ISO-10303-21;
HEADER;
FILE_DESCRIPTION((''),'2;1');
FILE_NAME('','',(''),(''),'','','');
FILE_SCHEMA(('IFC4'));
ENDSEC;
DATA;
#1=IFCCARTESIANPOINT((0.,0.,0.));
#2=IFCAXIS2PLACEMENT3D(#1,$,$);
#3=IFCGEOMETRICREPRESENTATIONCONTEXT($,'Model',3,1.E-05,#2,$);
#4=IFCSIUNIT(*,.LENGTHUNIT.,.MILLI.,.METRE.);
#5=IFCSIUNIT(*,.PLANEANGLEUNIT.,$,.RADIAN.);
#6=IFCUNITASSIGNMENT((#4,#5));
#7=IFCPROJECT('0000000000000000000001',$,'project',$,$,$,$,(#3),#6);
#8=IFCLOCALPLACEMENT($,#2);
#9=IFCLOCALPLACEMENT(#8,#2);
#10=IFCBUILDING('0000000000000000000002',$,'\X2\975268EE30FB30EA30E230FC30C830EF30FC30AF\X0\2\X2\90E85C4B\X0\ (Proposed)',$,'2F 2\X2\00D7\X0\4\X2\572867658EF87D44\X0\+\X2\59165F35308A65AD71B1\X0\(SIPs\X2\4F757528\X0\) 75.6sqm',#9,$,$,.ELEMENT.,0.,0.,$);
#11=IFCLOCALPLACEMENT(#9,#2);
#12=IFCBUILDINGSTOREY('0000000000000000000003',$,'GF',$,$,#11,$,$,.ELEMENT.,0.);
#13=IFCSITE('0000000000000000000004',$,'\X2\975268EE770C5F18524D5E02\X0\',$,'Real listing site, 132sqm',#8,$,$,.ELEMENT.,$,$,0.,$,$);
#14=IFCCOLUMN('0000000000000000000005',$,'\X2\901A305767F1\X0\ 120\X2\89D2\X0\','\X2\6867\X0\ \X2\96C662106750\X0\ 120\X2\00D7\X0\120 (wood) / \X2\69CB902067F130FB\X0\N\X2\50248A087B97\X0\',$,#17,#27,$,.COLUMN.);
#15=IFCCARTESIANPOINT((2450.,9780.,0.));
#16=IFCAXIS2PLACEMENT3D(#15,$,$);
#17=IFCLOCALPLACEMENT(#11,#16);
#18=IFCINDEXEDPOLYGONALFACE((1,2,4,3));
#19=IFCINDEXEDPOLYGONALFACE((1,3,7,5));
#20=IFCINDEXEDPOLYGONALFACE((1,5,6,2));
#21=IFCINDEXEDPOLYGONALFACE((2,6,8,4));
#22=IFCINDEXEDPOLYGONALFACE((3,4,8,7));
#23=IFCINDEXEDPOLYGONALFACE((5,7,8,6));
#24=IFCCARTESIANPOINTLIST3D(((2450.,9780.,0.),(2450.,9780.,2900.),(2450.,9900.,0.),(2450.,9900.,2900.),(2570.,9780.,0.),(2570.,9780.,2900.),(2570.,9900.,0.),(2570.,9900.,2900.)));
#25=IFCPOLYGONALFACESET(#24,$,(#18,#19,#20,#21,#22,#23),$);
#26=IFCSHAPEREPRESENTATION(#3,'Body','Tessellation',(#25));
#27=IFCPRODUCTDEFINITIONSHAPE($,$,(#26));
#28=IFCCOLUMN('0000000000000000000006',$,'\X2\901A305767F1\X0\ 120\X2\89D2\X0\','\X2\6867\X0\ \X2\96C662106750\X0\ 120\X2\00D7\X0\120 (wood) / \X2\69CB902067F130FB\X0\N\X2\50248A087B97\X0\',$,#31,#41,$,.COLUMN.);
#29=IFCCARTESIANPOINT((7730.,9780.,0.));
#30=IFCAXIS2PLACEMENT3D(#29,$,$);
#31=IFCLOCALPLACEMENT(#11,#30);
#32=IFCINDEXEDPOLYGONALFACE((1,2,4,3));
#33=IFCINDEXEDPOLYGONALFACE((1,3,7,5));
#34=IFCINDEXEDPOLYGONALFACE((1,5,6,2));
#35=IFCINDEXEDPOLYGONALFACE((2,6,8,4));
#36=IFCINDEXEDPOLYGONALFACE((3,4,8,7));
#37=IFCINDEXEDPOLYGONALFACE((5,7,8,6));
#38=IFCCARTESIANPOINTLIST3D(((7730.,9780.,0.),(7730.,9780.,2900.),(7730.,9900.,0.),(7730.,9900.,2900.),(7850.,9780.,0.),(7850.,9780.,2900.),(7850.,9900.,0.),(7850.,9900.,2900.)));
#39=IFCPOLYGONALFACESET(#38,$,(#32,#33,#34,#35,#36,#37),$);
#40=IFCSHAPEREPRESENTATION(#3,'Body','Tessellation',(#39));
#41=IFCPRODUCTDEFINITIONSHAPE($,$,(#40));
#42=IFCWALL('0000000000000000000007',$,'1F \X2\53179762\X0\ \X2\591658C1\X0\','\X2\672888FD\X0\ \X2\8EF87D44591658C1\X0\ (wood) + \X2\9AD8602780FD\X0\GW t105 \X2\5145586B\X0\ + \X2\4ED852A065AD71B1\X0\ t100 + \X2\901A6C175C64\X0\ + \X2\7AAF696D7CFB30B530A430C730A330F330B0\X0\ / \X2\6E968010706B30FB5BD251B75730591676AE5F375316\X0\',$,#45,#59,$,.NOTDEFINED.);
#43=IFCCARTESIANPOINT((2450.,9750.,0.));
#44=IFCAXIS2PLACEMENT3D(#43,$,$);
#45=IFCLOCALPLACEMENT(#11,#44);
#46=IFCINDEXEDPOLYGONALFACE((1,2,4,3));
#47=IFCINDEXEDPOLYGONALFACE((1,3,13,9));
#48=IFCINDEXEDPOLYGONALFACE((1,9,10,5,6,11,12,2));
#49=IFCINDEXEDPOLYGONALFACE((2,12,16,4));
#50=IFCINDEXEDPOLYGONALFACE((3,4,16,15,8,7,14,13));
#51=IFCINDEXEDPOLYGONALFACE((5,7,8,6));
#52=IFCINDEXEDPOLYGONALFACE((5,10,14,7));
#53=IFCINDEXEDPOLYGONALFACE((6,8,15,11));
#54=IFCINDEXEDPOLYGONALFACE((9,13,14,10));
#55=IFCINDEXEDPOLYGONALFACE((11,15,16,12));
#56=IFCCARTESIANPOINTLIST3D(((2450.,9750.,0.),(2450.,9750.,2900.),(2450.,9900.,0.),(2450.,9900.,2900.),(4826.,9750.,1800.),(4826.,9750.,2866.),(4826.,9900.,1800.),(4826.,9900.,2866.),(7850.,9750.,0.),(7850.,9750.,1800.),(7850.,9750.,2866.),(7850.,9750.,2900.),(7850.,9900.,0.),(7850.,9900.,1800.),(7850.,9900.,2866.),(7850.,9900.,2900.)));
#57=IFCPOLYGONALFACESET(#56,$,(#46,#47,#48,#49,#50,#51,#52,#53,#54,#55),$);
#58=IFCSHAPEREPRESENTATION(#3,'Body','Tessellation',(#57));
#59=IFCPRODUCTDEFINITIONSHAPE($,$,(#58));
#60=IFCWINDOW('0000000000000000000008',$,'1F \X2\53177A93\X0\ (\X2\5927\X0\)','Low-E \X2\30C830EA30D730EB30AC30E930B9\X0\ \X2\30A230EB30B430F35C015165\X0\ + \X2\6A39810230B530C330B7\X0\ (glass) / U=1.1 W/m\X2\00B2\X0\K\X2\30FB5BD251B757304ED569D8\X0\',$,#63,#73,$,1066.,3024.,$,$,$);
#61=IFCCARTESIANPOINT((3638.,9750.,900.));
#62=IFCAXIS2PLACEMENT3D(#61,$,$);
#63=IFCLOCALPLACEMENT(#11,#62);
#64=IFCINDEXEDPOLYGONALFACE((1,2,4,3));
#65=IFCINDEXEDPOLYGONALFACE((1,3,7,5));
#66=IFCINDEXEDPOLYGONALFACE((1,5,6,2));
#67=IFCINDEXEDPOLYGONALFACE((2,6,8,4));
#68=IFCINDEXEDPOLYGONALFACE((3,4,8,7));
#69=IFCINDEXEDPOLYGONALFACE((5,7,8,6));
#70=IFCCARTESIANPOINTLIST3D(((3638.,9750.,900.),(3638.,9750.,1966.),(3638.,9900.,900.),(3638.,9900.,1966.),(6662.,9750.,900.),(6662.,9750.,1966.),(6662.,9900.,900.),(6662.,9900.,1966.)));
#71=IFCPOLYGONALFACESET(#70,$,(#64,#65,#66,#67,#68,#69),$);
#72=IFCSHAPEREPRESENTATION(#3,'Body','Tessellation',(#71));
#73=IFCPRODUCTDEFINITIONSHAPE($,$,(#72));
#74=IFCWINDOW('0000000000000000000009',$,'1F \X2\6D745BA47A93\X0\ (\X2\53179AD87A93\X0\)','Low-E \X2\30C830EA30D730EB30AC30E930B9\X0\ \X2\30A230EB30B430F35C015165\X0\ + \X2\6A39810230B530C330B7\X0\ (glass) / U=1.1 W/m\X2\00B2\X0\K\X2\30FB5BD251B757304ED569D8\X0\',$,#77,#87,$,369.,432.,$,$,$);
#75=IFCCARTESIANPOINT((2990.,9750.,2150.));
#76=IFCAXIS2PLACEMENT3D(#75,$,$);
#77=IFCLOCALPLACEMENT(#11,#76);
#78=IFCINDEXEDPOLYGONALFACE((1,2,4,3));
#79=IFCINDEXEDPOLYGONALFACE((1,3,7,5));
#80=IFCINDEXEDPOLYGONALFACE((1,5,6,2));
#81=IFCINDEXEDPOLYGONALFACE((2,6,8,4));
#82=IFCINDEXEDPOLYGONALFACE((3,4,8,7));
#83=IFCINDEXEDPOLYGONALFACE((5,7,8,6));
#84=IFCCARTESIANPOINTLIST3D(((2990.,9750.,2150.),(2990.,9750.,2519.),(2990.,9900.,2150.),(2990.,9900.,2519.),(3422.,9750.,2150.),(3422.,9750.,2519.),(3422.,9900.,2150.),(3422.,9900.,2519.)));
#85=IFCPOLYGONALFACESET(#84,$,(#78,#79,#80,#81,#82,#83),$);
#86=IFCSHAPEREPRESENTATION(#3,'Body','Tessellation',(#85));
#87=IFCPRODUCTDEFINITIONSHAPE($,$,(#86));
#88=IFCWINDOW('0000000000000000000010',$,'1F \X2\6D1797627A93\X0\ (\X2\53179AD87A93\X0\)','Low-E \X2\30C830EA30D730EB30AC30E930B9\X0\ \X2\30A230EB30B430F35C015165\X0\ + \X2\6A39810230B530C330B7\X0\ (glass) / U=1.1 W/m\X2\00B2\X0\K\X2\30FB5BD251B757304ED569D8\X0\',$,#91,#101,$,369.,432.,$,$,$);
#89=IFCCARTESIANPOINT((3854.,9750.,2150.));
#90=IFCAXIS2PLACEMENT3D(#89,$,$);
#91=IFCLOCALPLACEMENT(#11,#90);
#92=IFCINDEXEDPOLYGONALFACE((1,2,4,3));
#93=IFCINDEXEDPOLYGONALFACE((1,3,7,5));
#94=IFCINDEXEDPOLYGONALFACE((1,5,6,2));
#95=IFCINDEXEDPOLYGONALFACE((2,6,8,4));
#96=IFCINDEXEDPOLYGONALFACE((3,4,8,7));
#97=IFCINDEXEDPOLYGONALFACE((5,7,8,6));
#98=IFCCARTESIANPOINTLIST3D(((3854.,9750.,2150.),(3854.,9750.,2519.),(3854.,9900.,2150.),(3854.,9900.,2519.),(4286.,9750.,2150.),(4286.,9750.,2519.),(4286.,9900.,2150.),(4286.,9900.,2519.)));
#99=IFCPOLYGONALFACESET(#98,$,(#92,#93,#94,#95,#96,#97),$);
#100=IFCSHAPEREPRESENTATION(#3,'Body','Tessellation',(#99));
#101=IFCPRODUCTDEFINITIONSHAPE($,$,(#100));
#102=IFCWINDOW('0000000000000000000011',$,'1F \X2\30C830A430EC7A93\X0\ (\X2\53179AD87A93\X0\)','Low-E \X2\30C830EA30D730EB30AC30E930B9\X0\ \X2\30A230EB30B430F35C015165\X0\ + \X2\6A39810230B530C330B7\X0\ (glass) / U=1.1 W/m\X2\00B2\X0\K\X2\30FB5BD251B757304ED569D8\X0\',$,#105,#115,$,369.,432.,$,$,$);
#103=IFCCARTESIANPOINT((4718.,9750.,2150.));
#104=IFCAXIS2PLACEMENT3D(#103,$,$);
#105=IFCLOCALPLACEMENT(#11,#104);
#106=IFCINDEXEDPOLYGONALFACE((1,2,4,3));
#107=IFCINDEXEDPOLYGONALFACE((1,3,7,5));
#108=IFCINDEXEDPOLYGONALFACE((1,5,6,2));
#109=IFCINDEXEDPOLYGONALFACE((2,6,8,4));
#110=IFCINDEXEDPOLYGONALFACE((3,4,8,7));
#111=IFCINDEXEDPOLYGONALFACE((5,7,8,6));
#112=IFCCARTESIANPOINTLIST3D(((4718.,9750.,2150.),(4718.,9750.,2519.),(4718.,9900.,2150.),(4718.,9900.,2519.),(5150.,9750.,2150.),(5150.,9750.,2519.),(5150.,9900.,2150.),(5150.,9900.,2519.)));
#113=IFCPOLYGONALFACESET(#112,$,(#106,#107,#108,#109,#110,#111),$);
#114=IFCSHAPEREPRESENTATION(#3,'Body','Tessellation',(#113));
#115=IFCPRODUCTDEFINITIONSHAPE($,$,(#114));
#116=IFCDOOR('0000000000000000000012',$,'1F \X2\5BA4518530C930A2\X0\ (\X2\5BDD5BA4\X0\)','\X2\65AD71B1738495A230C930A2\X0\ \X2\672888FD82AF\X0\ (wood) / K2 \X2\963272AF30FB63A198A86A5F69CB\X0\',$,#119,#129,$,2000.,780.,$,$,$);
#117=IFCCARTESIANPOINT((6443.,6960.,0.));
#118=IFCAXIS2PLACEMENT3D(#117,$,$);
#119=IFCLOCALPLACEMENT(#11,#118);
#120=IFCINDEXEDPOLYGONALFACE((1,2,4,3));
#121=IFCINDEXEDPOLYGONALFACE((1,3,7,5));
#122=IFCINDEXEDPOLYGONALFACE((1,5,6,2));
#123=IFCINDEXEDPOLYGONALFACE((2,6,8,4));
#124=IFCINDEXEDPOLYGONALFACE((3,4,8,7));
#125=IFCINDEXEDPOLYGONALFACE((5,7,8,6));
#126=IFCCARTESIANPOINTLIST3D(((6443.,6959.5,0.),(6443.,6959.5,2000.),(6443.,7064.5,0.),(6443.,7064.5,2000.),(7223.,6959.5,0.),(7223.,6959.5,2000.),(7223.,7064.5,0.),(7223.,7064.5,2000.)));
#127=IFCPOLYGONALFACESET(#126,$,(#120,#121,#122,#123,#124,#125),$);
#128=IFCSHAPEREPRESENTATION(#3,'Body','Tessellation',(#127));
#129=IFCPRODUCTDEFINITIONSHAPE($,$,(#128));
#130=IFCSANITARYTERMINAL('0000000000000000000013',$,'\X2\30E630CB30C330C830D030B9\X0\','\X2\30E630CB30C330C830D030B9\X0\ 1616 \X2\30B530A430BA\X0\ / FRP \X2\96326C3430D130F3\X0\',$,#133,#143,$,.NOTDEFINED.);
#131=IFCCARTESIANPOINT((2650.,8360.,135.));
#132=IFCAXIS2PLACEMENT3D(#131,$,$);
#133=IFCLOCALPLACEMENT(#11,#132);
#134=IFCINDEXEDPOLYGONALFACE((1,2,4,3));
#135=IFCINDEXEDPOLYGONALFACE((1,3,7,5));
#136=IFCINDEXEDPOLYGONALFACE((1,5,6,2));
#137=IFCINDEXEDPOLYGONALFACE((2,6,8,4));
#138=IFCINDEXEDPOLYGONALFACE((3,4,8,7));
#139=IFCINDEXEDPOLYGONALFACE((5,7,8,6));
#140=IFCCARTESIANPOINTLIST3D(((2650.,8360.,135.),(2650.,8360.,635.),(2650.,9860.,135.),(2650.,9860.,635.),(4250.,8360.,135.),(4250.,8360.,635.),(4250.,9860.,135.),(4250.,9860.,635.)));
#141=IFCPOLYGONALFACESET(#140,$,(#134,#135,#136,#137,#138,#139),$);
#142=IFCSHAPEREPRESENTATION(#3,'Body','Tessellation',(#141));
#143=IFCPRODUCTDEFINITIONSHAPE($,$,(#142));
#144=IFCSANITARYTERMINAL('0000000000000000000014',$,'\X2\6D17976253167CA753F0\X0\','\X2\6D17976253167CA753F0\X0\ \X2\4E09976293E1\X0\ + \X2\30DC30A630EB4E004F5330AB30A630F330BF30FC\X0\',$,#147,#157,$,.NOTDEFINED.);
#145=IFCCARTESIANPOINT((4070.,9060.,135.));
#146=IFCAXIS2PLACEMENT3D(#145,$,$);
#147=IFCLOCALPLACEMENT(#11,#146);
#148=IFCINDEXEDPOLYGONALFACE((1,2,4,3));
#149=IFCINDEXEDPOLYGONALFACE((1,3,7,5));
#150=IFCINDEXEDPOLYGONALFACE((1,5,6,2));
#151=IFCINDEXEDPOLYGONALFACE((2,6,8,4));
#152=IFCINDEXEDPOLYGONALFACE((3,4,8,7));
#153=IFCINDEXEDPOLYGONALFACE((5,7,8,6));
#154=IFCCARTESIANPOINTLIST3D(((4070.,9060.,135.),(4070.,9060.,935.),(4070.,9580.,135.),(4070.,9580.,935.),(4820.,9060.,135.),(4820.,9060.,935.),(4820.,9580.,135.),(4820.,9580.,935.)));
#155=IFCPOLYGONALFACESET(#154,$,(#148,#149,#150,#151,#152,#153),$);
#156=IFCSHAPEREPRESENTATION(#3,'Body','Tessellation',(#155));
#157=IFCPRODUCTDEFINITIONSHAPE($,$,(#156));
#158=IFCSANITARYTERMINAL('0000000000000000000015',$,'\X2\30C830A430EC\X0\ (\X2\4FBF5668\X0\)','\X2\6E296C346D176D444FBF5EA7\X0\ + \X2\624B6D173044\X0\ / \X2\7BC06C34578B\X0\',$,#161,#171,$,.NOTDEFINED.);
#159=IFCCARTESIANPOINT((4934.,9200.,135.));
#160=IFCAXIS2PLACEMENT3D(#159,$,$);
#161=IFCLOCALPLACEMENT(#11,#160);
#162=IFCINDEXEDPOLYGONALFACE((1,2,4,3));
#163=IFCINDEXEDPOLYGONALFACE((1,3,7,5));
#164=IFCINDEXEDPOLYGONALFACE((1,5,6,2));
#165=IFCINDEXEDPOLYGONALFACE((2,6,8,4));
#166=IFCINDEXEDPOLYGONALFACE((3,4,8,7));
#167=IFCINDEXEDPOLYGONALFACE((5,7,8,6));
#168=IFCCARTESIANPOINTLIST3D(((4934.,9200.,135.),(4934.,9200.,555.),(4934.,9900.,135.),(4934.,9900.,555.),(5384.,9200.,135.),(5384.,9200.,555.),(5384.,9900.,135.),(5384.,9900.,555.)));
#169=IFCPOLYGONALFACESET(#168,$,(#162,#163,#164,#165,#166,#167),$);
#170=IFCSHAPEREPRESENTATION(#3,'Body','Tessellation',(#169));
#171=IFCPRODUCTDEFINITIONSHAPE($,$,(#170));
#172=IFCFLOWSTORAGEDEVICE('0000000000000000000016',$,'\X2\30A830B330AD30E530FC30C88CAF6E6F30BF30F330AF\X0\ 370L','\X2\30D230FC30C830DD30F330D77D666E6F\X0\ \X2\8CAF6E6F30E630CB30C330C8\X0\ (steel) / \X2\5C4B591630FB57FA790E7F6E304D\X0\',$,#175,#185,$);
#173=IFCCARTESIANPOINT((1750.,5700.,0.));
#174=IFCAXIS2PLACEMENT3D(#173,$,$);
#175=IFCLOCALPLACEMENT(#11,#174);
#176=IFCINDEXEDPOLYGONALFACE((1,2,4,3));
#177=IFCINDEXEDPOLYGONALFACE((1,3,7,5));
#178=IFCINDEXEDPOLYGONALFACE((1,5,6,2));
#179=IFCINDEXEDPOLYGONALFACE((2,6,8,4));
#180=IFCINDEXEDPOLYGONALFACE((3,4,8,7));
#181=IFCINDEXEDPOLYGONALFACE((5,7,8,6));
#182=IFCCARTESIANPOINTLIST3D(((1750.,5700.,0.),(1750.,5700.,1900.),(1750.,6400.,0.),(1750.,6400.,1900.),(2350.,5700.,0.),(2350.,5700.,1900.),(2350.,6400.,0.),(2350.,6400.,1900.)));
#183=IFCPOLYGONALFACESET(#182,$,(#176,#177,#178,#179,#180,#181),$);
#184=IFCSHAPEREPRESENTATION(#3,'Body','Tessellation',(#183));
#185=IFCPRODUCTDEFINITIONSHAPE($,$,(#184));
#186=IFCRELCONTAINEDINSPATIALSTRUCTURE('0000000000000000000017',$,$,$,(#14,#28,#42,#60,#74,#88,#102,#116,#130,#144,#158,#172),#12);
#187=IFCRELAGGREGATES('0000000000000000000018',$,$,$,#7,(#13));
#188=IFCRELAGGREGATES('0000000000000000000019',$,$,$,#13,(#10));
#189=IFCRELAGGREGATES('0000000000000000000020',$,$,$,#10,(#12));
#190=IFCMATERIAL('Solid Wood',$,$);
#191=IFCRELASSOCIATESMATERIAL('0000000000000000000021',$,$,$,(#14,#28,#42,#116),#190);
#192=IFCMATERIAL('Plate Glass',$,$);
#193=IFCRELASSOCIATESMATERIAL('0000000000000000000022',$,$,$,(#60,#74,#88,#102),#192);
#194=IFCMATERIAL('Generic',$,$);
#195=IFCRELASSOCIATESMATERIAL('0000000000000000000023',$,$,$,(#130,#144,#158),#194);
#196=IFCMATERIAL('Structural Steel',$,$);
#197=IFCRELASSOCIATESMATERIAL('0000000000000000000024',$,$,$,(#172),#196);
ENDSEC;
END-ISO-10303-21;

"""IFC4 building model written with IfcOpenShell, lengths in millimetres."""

from ifc_helpers import new_model, si_unit, frame, frame_2d, origin, place, context, project, spatial, rectangle, extrude, material, element, fill, save


model = new_model("IFC4")

# Units and contexts
model_context = context("Model", 3, precision=1e-05, world=origin())
ifc_project = project(units=[si_unit("LENGTHUNIT", "METRE", prefix="MILLI"), si_unit("PLANEANGLEUNIT", "RADIAN")], contexts=[model_context])

# Site, building, storey
site_placement = place(None, origin())
site = spatial("IfcSite", under=ifc_project, at=site_placement, Name="青森県弘前市", ObjectType="Real listing site, 132sqm", CompositionType="ELEMENT", RefElevation=0.0)
building_placement = place(site_placement, origin())
building = spatial("IfcBuilding", under=site, at=building_placement, Name="青森・リモートワーク2部屋 (Proposed)", ObjectType="2F 2×4在来軸組+外張り断熱(SIPs併用) 75.6sqm", CompositionType="ELEMENT", ElevationOfRefHeight=0.0, ElevationOfTerrain=0.0)
storey_placement = place(building_placement, origin())
storey = spatial("IfcBuildingStorey", under=building, at=storey_placement, Name="GF", CompositionType="ELEMENT", Elevation=0.0)

# Columns
ifc_material_1 = material(Name="Solid Wood")
column_1_placement = place(storey_placement, frame((2450.0, 9780.0, 0.0)))
element("IfcColumn", 1, at=column_1_placement, inside=storey, material=ifc_material_1, Name="通し柱 120角", Description="桧 集成材 120×120 (wood) / 構造柱・N値計算", PredefinedType="COLUMN", context=model_context, shape_type="SweptSolid", body=[
    extrude(rectangle(XDim=120.0, YDim=120.0, at=frame_2d((60.0, 60.0))), frame((2450.0, 9780.0, 0.0)), (0.0, 0.0, 1.0), 2900.0),
])
column_2_placement = place(storey_placement, frame((7730.0, 9780.0, 0.0)))
element("IfcColumn", 2, at=column_2_placement, inside=storey, material=ifc_material_1, Name="通し柱 120角", Description="桧 集成材 120×120 (wood) / 構造柱・N値計算", PredefinedType="COLUMN", context=model_context, shape_type="SweptSolid", body=[
    extrude(rectangle(XDim=120.0, YDim=120.0, at=frame_2d((60.0, 60.0))), frame((7730.0, 9780.0, 0.0)), (0.0, 0.0, 1.0), 2900.0),
])

# Wall, openings, windows
wall_1_placement = place(storey_placement, frame((2450.0, 9750.0, 0.0)))
wall_1 = element("IfcWall", 3, at=wall_1_placement, inside=storey, material=ifc_material_1, Name="1F 北面 外壁", Description="木製 軸組外壁 (wood) + 高性能GW t105 充填 + 付加断熱 t100 + 通気層 + 窯業系サイディング / 準耐火・寒冷地外皮強化", PredefinedType="NOTDEFINED", context=model_context, shape_type="SweptSolid", body=[
    extrude(rectangle(XDim=5400.0, YDim=150.0, at=frame_2d((2700.0, 75.0))), frame((2450.0, 9750.0, 0.0)), (0.0, 0.0, 1.0), 2900.0),
])
opening_1_placement = place(storey_placement, frame((3638.0, 9750.0, 900.0)))
opening_1 = element("IfcOpeningElement", 4, at=opening_1_placement, cuts=wall_1, PredefinedType="NOTDEFINED", context=model_context, shape_type="SweptSolid", body=[
    extrude(rectangle(XDim=3024.0, YDim=150.0, at=frame_2d((1512.0, 75.0))), frame((3638.0, 9750.0, 900.0)), (0.0, 0.0, 1.0), 1066.0),
])
opening_2_placement = place(storey_placement, frame((2990.0, 9750.0, 2150.0)))
opening_2 = element("IfcOpeningElement", 5, at=opening_2_placement, cuts=wall_1, PredefinedType="NOTDEFINED", context=model_context, shape_type="SweptSolid", body=[
    extrude(rectangle(XDim=432.0, YDim=150.0, at=frame_2d((216.0, 75.0))), frame((2990.0, 9750.0, 2150.0)), (0.0, 0.0, 1.0), 369.0),
])
opening_3_placement = place(storey_placement, frame((3854.0, 9750.0, 2150.0)))
opening_3 = element("IfcOpeningElement", 6, at=opening_3_placement, cuts=wall_1, PredefinedType="NOTDEFINED", context=model_context, shape_type="SweptSolid", body=[
    extrude(rectangle(XDim=432.0, YDim=150.0, at=frame_2d((216.0, 75.0))), frame((3854.0, 9750.0, 2150.0)), (0.0, 0.0, 1.0), 369.0),
])
opening_4_placement = place(storey_placement, frame((4718.0, 9750.0, 2150.0)))
opening_4 = element("IfcOpeningElement", 7, at=opening_4_placement, cuts=wall_1, PredefinedType="NOTDEFINED", context=model_context, shape_type="SweptSolid", body=[
    extrude(rectangle(XDim=432.0, YDim=150.0, at=frame_2d((216.0, 75.0))), frame((4718.0, 9750.0, 2150.0)), (0.0, 0.0, 1.0), 369.0),
])
ifc_material_2 = material(Name="Plate Glass")
window_1_placement = place(storey_placement, frame((3638.0, 9750.0, 900.0)))
window_1 = element("IfcWindow", 8, at=window_1_placement, inside=storey, material=ifc_material_2, Name="1F 北窓 (大)", Description="Low-E トリプルガラス アルゴン封入 + 樹脂サッシ (glass) / U=1.1 W/m²K・寒冷地仕様", OverallHeight=1066.0, OverallWidth=3024.0, context=model_context, shape_type="SweptSolid", body=[
    extrude(rectangle(XDim=3024.0, YDim=150.0, at=frame_2d((1512.0, 75.0))), frame((3638.0, 9750.0, 900.0)), (0.0, 0.0, 1.0), 1066.0),
])
fill(opening_1, window_1)
window_2_placement = place(storey_placement, frame((2990.0, 9750.0, 2150.0)))
window_2 = element("IfcWindow", 9, at=window_2_placement, inside=storey, material=ifc_material_2, Name="1F 浴室窓 (北高窓)", Description="Low-E トリプルガラス アルゴン封入 + 樹脂サッシ (glass) / U=1.1 W/m²K・寒冷地仕様", OverallHeight=369.0, OverallWidth=432.0, context=model_context, shape_type="SweptSolid", body=[
    extrude(rectangle(XDim=432.0, YDim=150.0, at=frame_2d((216.0, 75.0))), frame((2990.0, 9750.0, 2150.0)), (0.0, 0.0, 1.0), 369.0),
])
fill(opening_2, window_2)
window_3_placement = place(storey_placement, frame((3854.0, 9750.0, 2150.0)))
window_3 = element("IfcWindow", 10, at=window_3_placement, inside=storey, material=ifc_material_2, Name="1F 洗面窓 (北高窓)", Description="Low-E トリプルガラス アルゴン封入 + 樹脂サッシ (glass) / U=1.1 W/m²K・寒冷地仕様", OverallHeight=369.0, OverallWidth=432.0, context=model_context, shape_type="SweptSolid", body=[
    extrude(rectangle(XDim=432.0, YDim=150.0, at=frame_2d((216.0, 75.0))), frame((3854.0, 9750.0, 2150.0)), (0.0, 0.0, 1.0), 369.0),
])
fill(opening_3, window_3)
window_4_placement = place(storey_placement, frame((4718.0, 9750.0, 2150.0)))
window_4 = element("IfcWindow", 11, at=window_4_placement, inside=storey, material=ifc_material_2, Name="1F トイレ窓 (北高窓)", Description="Low-E トリプルガラス アルゴン封入 + 樹脂サッシ (glass) / U=1.1 W/m²K・寒冷地仕様", OverallHeight=369.0, OverallWidth=432.0, context=model_context, shape_type="SweptSolid", body=[
    extrude(rectangle(XDim=432.0, YDim=150.0, at=frame_2d((216.0, 75.0))), frame((4718.0, 9750.0, 2150.0)), (0.0, 0.0, 1.0), 369.0),
])
fill(opening_4, window_4)

# Door
door_1_placement = place(storey_placement, frame((6443.0, 6960.0, 0.0)))
element("IfcDoor", 12, at=door_1_placement, inside=storey, material=ifc_material_1, Name="1F 室内ドア (寝室)", Description="断熱玄関ドア 木製芯 (wood) / K2 防犯・採風機構", OverallHeight=2000.0, OverallWidth=780.0, context=model_context, shape_type="SweptSolid", body=[
    extrude(rectangle(XDim=780.0, YDim=105.0, at=frame_2d((390.0, 52.0))), frame((6443.0, 6960.0, 0.0)), (0.0, 0.0, 1.0), 2000.0),
])

# Sanitary terminals
ifc_material_3 = material(Name="Generic")
sanitary_terminal_1_placement = place(storey_placement, frame((2650.0, 8360.0, 135.0)))
element("IfcSanitaryTerminal", 13, at=sanitary_terminal_1_placement, inside=storey, material=ifc_material_3, Name="ユニットバス", Description="ユニットバス 1616 サイズ / FRP 防水パン", PredefinedType="NOTDEFINED", context=model_context, shape_type="SweptSolid", body=[
    extrude(rectangle(XDim=1600.0, YDim=1500.0, at=frame_2d((800.0, 750.0))), frame((2650.0, 8360.0, 135.0)), (0.0, 0.0, 1.0), 500.0),
])
sanitary_terminal_2_placement = place(storey_placement, frame((4070.0, 9060.0, 135.0)))
element("IfcSanitaryTerminal", 14, at=sanitary_terminal_2_placement, inside=storey, material=ifc_material_3, Name="洗面化粧台", Description="洗面化粧台 三面鏡 + ボウル一体カウンター", PredefinedType="NOTDEFINED", context=model_context, shape_type="SweptSolid", body=[
    extrude(rectangle(XDim=750.0, YDim=520.0, at=frame_2d((375.0, 260.0))), frame((4070.0, 9060.0, 135.0)), (0.0, 0.0, 1.0), 800.0),
])
sanitary_terminal_3_placement = place(storey_placement, frame((4934.0, 9200.0, 135.0)))
element("IfcSanitaryTerminal", 15, at=sanitary_terminal_3_placement, inside=storey, material=ifc_material_3, Name="トイレ (便器)", Description="温水洗浄便座 + 手洗い / 節水型", PredefinedType="NOTDEFINED", context=model_context, shape_type="SweptSolid", body=[
    extrude(rectangle(XDim=450.0, YDim=700.0, at=frame_2d((225.0, 350.0))), frame((4934.0, 9200.0, 135.0)), (0.0, 0.0, 1.0), 420.0),
])

# Flow storage device
ifc_material_4 = material(Name="Structural Steel")
flow_storage_device_placement = place(storey_placement, frame((1750.0, 5700.0, 0.0)))
element("IfcFlowStorageDevice", 16, at=flow_storage_device_placement, inside=storey, material=ifc_material_4, Name="エコキュート貯湯タンク 370L", Description="ヒートポンプ給湯 貯湯ユニット (steel) / 屋外・基礎置き", context=model_context, shape_type="SweptSolid", body=[
    extrude(rectangle(XDim=600.0, YDim=700.0, at=frame_2d((300.0, 350.0))), frame((1750.0, 5700.0, 0.0)), (0.0, 0.0, 1.0), 1900.0),
])

save(model, "model.ifc")
